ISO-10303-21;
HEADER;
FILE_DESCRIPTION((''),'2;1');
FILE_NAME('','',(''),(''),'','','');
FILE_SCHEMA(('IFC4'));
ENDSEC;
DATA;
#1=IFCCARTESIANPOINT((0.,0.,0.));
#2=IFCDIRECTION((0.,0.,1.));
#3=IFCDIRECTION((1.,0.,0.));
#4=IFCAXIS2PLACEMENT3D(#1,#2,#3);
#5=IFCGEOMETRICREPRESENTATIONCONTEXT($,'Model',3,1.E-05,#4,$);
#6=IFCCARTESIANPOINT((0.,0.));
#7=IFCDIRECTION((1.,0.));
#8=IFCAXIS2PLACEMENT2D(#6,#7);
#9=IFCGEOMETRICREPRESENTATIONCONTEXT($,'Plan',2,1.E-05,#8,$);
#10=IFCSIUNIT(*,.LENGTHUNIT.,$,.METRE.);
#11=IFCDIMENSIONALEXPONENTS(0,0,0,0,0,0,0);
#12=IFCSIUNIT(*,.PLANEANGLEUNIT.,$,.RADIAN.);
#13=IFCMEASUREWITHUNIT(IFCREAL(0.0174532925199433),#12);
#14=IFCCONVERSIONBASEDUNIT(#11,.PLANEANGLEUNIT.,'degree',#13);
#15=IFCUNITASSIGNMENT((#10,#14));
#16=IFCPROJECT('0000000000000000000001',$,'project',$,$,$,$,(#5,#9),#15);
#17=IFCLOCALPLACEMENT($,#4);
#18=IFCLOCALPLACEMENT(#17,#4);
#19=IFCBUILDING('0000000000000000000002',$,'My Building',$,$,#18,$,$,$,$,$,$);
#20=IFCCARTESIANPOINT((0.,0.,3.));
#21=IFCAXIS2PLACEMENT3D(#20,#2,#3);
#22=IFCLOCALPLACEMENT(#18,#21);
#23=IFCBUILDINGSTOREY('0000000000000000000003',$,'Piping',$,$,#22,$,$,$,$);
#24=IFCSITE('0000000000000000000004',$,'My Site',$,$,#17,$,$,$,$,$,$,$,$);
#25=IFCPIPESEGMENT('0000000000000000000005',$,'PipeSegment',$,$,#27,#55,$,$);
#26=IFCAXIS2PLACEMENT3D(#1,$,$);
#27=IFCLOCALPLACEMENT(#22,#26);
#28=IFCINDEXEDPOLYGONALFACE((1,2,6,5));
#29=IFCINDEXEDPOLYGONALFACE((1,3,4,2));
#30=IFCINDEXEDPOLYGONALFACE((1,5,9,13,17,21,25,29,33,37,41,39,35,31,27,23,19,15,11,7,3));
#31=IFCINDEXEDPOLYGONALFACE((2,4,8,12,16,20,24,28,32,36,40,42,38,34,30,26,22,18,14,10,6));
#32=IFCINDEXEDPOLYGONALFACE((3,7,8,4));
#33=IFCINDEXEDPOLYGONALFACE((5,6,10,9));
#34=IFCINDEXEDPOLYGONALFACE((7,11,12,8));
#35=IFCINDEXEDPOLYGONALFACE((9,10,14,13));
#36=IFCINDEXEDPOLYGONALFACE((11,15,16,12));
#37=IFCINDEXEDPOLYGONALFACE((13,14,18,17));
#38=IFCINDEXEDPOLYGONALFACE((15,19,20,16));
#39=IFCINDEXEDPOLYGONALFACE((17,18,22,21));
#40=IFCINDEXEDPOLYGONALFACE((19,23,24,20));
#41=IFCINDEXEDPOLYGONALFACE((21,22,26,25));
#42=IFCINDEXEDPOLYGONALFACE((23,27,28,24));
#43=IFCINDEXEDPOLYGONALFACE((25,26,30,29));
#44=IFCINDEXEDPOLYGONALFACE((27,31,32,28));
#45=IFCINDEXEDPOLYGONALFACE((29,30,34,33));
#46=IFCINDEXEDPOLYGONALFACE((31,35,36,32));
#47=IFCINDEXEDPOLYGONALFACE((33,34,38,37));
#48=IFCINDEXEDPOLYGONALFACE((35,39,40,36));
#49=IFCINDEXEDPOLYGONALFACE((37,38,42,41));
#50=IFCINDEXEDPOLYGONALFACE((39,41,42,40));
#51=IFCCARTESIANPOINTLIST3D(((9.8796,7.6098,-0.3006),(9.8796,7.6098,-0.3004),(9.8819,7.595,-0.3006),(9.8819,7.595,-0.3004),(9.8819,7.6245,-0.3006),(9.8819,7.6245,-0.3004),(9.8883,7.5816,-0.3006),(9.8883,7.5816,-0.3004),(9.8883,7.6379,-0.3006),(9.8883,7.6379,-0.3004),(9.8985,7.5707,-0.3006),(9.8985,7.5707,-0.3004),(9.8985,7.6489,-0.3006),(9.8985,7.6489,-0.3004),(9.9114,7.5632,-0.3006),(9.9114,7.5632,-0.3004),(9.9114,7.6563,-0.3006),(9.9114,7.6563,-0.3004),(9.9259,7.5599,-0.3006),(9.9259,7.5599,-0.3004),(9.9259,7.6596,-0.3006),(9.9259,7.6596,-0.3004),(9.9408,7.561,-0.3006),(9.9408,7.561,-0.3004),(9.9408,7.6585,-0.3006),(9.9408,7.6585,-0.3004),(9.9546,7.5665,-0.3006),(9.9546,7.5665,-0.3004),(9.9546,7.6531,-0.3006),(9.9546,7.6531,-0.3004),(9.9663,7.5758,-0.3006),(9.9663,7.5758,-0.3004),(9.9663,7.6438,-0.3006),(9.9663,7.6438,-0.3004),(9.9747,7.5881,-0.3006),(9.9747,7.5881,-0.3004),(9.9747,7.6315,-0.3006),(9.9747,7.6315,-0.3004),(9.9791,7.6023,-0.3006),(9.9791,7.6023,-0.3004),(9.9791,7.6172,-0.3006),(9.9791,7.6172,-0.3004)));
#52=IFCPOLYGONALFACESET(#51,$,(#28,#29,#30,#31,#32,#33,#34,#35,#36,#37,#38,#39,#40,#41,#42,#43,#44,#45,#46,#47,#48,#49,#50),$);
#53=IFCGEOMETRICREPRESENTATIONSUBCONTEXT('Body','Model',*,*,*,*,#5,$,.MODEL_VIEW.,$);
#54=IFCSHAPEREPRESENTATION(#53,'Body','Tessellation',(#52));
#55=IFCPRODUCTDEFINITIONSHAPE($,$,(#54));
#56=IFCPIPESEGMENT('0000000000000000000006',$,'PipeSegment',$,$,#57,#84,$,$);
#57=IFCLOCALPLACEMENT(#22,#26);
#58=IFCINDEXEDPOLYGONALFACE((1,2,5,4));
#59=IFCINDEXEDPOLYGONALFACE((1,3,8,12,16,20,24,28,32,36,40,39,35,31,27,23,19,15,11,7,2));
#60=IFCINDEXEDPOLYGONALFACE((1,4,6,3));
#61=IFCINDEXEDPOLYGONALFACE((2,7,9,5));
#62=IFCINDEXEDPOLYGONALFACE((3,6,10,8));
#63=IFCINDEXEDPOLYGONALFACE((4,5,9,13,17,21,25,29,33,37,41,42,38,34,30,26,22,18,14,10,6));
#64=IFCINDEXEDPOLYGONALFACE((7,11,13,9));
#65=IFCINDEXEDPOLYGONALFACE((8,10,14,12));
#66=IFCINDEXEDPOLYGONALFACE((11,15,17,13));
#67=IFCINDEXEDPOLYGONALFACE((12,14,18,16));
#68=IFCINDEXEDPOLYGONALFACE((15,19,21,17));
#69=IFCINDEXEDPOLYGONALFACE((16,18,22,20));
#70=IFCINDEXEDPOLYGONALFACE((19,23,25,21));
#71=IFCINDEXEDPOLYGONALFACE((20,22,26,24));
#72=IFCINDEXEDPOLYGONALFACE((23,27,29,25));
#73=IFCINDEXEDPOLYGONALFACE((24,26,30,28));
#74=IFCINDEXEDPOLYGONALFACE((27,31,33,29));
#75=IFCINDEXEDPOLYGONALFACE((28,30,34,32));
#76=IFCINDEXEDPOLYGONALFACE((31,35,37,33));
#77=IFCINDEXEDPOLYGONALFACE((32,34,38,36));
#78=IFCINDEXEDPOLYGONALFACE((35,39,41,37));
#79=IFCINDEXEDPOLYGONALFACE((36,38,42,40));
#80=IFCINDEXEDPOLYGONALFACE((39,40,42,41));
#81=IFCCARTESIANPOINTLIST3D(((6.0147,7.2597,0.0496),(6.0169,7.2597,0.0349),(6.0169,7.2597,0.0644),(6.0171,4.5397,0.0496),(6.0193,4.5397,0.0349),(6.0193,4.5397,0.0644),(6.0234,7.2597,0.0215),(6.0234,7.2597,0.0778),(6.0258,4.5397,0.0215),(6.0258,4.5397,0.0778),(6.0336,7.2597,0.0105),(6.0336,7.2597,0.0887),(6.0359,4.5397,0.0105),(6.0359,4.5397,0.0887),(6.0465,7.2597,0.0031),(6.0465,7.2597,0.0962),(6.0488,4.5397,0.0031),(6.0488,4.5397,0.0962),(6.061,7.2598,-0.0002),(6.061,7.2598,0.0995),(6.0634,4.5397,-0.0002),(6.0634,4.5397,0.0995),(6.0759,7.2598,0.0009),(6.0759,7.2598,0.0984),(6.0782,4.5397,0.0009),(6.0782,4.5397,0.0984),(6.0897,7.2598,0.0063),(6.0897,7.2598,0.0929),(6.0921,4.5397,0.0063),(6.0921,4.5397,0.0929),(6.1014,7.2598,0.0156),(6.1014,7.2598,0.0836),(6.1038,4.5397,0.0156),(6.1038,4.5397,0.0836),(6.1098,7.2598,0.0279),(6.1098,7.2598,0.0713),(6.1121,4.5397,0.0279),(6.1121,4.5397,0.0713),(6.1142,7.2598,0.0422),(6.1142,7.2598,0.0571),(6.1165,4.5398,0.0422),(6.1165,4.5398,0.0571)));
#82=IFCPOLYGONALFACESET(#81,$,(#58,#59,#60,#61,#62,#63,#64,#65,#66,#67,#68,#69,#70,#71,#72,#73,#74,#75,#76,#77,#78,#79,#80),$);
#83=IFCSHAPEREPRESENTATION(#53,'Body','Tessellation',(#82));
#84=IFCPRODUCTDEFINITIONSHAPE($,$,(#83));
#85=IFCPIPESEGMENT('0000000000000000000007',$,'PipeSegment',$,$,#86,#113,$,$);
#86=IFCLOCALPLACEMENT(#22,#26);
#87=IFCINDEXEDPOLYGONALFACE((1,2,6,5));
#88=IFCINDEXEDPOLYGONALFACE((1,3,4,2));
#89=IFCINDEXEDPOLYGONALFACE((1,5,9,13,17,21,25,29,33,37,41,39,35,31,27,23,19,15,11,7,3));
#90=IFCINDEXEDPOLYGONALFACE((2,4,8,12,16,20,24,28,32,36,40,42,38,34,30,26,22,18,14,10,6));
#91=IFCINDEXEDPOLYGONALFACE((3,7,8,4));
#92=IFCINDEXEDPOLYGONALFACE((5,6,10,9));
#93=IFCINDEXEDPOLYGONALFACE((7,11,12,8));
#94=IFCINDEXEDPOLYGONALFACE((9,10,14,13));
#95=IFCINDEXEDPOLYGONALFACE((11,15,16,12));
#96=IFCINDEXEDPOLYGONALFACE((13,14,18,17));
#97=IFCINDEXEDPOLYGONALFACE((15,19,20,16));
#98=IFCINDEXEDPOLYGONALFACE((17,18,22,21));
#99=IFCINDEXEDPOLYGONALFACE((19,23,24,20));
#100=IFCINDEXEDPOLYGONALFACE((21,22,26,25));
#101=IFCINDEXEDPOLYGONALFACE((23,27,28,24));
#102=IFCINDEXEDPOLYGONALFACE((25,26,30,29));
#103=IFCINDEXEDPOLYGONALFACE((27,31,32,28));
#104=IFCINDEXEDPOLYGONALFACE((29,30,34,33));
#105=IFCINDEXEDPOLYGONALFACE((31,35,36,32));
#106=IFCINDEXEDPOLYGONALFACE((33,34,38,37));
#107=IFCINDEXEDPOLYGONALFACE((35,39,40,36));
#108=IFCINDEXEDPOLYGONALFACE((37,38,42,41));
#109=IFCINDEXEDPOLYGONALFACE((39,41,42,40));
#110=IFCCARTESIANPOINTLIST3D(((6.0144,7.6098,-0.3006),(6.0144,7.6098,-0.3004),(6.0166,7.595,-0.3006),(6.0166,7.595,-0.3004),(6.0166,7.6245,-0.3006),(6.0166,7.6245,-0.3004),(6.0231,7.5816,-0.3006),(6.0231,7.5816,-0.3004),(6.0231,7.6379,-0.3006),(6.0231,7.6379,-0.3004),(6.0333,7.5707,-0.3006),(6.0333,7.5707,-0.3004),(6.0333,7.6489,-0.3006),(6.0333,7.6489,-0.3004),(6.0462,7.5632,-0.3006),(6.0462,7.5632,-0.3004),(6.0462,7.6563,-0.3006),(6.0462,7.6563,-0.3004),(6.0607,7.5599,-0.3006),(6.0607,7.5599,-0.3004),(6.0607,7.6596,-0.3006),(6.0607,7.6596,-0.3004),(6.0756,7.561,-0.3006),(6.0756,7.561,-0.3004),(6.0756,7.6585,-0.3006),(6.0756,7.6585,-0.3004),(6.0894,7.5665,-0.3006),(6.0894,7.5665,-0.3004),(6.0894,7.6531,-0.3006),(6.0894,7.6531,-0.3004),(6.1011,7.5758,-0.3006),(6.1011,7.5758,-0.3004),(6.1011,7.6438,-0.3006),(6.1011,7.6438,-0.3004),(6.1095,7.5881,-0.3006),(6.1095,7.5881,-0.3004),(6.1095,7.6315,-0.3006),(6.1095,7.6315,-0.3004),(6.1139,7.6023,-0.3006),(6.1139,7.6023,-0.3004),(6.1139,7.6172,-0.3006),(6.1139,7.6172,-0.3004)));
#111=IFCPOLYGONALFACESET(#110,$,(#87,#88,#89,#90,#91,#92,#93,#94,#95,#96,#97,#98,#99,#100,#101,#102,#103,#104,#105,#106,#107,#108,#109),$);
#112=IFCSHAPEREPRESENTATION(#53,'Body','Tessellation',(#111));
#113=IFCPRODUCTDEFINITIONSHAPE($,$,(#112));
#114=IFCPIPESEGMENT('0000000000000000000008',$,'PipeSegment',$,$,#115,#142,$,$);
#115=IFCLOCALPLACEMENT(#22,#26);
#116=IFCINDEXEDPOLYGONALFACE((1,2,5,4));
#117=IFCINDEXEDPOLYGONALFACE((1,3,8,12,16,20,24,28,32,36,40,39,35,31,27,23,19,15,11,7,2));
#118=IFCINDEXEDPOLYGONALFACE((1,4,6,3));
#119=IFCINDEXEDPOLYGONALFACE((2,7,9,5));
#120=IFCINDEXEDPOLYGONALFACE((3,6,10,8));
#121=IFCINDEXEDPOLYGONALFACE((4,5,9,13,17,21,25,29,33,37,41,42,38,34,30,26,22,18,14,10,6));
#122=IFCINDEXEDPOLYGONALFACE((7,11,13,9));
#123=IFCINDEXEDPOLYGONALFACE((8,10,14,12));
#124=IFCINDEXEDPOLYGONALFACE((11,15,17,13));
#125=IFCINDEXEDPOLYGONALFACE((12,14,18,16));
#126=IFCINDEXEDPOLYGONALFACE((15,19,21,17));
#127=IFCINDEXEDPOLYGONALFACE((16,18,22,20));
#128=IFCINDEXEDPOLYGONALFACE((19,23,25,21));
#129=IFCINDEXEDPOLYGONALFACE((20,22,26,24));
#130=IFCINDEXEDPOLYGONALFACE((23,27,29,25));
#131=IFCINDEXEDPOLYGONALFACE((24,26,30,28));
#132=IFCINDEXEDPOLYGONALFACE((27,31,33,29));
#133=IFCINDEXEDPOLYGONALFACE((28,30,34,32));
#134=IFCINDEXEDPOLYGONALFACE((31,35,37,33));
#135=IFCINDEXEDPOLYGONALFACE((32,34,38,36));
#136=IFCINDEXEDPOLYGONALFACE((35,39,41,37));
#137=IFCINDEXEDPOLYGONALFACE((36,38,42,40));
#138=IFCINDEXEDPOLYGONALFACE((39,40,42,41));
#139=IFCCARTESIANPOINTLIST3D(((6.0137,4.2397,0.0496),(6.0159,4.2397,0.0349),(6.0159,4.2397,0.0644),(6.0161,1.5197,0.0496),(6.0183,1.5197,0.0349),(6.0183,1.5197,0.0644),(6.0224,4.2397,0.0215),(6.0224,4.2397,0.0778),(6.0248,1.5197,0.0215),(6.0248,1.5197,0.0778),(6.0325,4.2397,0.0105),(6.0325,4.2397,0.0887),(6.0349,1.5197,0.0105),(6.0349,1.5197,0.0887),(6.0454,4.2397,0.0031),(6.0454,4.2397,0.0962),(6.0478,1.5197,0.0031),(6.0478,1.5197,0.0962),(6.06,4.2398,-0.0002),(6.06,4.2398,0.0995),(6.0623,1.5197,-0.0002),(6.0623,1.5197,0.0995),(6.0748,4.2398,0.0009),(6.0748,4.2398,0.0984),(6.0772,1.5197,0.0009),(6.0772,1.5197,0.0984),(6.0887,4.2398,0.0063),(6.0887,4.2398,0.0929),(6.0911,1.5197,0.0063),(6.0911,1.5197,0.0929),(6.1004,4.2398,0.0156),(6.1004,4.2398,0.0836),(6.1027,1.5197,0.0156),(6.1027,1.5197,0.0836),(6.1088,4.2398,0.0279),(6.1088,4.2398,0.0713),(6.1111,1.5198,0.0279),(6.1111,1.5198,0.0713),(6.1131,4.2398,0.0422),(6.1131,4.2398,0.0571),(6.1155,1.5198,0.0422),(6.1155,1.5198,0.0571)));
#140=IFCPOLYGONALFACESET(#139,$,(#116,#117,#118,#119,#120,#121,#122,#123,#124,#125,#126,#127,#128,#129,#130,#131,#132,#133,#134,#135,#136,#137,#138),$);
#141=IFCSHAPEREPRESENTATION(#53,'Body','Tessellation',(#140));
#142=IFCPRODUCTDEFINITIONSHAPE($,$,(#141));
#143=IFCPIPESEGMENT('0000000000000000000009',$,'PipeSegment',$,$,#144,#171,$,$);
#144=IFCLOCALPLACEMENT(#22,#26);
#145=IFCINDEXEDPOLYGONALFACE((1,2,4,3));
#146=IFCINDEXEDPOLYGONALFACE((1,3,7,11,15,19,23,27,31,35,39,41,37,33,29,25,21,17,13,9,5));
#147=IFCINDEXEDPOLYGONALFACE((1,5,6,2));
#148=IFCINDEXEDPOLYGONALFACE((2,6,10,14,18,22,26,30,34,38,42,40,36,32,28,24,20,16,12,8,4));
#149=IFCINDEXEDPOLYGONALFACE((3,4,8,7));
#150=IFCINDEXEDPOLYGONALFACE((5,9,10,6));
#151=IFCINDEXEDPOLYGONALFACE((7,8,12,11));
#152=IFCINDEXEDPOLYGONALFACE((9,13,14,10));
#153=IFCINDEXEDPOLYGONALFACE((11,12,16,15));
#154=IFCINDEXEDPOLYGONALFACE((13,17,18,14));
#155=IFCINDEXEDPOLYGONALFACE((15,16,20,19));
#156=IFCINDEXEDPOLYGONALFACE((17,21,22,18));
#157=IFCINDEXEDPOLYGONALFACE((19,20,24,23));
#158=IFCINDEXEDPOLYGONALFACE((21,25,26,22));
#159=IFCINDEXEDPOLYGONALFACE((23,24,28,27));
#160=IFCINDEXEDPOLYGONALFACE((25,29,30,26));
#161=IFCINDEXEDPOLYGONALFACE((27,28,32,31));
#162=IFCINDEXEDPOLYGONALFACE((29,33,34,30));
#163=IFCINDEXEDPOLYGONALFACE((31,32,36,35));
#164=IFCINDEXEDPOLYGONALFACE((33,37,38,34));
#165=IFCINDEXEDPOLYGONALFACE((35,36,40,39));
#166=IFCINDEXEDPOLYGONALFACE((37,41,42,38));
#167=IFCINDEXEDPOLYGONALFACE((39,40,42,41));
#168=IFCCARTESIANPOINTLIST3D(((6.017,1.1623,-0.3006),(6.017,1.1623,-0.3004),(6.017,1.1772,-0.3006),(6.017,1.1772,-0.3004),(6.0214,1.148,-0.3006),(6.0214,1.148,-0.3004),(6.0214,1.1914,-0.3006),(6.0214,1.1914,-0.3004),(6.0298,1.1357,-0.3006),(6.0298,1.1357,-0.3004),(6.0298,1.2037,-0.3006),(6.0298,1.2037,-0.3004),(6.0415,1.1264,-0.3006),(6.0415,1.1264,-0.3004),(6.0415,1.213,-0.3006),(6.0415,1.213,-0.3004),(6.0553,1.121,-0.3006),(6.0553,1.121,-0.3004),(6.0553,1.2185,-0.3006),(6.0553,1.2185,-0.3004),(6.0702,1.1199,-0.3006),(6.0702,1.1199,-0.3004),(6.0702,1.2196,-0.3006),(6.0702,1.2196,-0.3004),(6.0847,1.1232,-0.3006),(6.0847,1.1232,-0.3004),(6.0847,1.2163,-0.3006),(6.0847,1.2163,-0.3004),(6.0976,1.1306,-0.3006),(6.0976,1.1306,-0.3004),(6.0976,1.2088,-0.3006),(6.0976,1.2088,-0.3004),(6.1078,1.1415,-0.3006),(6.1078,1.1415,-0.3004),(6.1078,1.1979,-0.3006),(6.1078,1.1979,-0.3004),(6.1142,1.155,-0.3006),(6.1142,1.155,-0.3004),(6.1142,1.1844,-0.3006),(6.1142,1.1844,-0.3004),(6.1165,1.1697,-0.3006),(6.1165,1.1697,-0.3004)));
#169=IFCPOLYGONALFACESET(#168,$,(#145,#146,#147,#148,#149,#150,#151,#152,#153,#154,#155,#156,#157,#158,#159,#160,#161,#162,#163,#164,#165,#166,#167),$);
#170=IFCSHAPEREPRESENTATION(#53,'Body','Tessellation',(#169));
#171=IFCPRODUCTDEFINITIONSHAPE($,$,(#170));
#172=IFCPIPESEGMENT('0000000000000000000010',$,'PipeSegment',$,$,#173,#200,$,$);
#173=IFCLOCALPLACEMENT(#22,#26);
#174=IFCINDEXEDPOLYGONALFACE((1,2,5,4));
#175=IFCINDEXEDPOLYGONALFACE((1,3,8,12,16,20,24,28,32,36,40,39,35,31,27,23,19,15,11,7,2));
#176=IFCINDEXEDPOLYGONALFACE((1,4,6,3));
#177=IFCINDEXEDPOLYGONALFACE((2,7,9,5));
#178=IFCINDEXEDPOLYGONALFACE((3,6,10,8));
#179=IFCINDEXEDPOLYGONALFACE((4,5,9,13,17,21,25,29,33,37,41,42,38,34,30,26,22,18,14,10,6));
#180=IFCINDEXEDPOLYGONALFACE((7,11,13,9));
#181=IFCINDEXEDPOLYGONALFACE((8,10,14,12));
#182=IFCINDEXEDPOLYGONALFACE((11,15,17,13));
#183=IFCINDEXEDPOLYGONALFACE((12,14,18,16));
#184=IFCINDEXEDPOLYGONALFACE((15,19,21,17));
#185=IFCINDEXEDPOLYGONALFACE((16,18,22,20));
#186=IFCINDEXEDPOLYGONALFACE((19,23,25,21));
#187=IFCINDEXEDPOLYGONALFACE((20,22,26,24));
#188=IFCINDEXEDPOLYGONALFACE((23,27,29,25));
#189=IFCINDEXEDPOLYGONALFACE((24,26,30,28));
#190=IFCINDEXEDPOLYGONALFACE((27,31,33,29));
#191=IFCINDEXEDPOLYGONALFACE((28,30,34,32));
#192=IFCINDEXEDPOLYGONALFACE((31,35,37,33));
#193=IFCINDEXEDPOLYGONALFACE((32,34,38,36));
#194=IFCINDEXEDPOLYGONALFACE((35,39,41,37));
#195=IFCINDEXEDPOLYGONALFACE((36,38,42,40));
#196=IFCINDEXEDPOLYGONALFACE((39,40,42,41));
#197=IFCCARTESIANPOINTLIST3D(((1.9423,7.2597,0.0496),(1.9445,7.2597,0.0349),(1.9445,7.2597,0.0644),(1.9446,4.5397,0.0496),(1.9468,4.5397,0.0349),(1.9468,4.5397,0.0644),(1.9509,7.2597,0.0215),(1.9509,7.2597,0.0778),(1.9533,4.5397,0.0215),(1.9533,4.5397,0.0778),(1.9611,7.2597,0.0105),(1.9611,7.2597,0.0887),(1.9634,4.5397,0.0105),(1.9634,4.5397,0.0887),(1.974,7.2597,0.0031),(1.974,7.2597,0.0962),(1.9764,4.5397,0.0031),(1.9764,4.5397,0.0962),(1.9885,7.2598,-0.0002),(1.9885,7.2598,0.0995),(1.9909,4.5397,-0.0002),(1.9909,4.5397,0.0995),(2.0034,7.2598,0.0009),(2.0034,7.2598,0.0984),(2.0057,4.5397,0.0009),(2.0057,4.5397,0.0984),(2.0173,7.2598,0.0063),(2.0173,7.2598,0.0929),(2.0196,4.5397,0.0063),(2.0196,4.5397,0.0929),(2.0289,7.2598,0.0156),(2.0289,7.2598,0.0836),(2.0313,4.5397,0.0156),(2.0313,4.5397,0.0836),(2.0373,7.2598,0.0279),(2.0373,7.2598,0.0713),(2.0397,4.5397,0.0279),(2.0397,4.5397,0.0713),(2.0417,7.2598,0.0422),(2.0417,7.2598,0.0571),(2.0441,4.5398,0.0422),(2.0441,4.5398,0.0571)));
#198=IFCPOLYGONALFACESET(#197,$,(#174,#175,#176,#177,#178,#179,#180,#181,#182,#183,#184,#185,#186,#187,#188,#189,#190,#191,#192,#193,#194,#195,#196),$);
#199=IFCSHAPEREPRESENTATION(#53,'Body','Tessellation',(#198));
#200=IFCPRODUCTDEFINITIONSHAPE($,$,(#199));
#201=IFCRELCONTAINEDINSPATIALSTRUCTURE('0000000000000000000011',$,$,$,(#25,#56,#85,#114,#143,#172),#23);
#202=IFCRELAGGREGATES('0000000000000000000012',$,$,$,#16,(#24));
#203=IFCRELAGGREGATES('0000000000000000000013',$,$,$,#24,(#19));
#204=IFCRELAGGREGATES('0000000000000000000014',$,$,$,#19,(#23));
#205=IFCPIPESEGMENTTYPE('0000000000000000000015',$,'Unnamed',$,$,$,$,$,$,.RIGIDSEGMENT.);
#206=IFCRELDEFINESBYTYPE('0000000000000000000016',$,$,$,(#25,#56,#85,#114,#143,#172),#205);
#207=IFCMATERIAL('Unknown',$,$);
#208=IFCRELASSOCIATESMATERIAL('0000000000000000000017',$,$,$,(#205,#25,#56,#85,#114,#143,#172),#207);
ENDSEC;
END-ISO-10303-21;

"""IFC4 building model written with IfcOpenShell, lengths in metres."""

from ifc_helpers import new_model, entity, si_unit, converted_unit, frame, origin_with_axes, origin_2d_with_axis, place, context, subcontext, project, spatial, circle, extrude, material, material_profile, profile_set, profile_usage, type_object, element, save


model = new_model("IFC4")

# Units and contexts
model_context = context("Model", 3, precision=1e-05, world=origin_with_axes())
plan_context = context("Plan", 2, precision=1e-05, world=origin_2d_with_axis())
body_context = subcontext(model_context, "Body", "Model", "MODEL_VIEW")
ifc_project = project(units=[si_unit("LENGTHUNIT", "METRE"), converted_unit("PLANEANGLEUNIT", "degree", entity("IfcReal", 0.0174532925199433), si_unit("PLANEANGLEUNIT", "RADIAN"), dimensions=[0, 0, 0, 0, 0, 0, 0])], contexts=[model_context, plan_context])

# Site, building, storey
site_placement = place(None, origin_with_axes())
site = spatial("IfcSite", under=ifc_project, at=site_placement, Name="My Site")
building_placement = place(site_placement, origin_with_axes())
building = spatial("IfcBuilding", under=site, at=building_placement, Name="My Building")
storey_placement = place(building_placement, frame((0.0, 0.0, 3.0), z_axis=(0.0, 0.0, 1.0), x_axis=(1.0, 0.0, 0.0)))
storey = spatial("IfcBuildingStorey", under=building, at=storey_placement, Name="Piping")

# Pipe segments
ifc_material = material(Name="Unknown")
ifc_material_profile_1 = material_profile(ifc_material, circle(Radius=0.05))
ifc_profile_set_1 = profile_set([ifc_material_profile_1])
ifc_profile_usage_1 = profile_usage(ifc_profile_set_1, cardinal=16)
pipe_segment_type = type_object("IfcPipeSegmentType", Name="Unnamed", PredefinedType="RIGIDSEGMENT", material=ifc_profile_set_1)
pipe_segment_1_placement = place(storey_placement, frame((9.9296, 7.6098, -0.3004), z_axis=(0.0, 0.0, -1.0), x_axis=(-1.0, 0.0, 0.0)))
element("IfcPipeSegment", 1, at=pipe_segment_1_placement, inside=storey, type_object=pipe_segment_type, material=ifc_profile_usage_1, Name="PipeSegment", context=body_context, shape_type="SweptSolid", body=[
    extrude(circle(Radius=0.05), origin_with_axes(), (0.0, 0.0, 1.0), 0.0002),
])
ifc_profile_usage_2 = profile_usage(ifc_profile_set_1, cardinal=5)
pipe_segment_2_placement = place(storey_placement, frame((6.0671, 4.5397, 0.0496), z_axis=(-0.000872, 1.0, 0.000001), x_axis=(-1.0, -0.000872, 0.0)))
element("IfcPipeSegment", 2, at=pipe_segment_2_placement, inside=storey, type_object=pipe_segment_type, material=ifc_profile_usage_2, Name="PipeSegment", context=body_context, shape_type="SweptSolid", body=[
    extrude(circle(Radius=0.05), origin_with_axes(), (0.0, 0.0, 1.0), 2.7201),
])
ifc_profile_usage_3 = profile_usage(ifc_profile_set_1, cardinal=16)
pipe_segment_3_placement = place(storey_placement, frame((6.0644, 7.6098, -0.3004), z_axis=(0.0, 0.0, -1.0), x_axis=(-1.0, 0.0, 0.0)))
element("IfcPipeSegment", 3, at=pipe_segment_3_placement, inside=storey, type_object=pipe_segment_type, material=ifc_profile_usage_3, Name="PipeSegment", context=body_context, shape_type="SweptSolid", body=[
    extrude(circle(Radius=0.05), origin_with_axes(), (0.0, 0.0, 1.0), 0.0002),
])
ifc_profile_usage_4 = profile_usage(ifc_profile_set_1, cardinal=5)
pipe_segment_4_placement = place(storey_placement, frame((6.0661, 1.5197, 0.0496), z_axis=(-0.000873, 1.0, 0.000001), x_axis=(-1.0, -0.000873, 0.0)))
element("IfcPipeSegment", 4, at=pipe_segment_4_placement, inside=storey, type_object=pipe_segment_type, material=ifc_profile_usage_4, Name="PipeSegment", context=body_context, shape_type="SweptSolid", body=[
    extrude(circle(Radius=0.05), origin_with_axes(), (0.0, 0.0, 1.0), 2.7201),
])
ifc_profile_usage_5 = profile_usage(ifc_profile_set_1, cardinal=16)
pipe_segment_5_placement = place(storey_placement, frame((6.0665, 1.1697, -0.3004), z_axis=(0.0, 0.0, -1.0), x_axis=(1.0, 0.0, 0.0)))
element("IfcPipeSegment", 5, at=pipe_segment_5_placement, inside=storey, type_object=pipe_segment_type, material=ifc_profile_usage_5, Name="PipeSegment", context=body_context, shape_type="SweptSolid", body=[
    extrude(circle(Radius=0.05), origin_with_axes(), (0.0, 0.0, 1.0), 0.0002),
])
ifc_profile_usage_6 = profile_usage(ifc_profile_set_1, cardinal=5)
pipe_segment_6_placement = place(storey_placement, frame((1.9946, 4.5397, 0.0496), z_axis=(-0.000872, 1.0, 0.000001), x_axis=(-1.0, -0.000872, 0.0)))
element("IfcPipeSegment", 6, at=pipe_segment_6_placement, inside=storey, type_object=pipe_segment_type, material=ifc_profile_usage_6, Name="PipeSegment", context=body_context, shape_type="SweptSolid", body=[
    extrude(circle(Radius=0.05), origin_with_axes(), (0.0, 0.0, 1.0), 2.7201),
])

save(model, "model.ifc")
